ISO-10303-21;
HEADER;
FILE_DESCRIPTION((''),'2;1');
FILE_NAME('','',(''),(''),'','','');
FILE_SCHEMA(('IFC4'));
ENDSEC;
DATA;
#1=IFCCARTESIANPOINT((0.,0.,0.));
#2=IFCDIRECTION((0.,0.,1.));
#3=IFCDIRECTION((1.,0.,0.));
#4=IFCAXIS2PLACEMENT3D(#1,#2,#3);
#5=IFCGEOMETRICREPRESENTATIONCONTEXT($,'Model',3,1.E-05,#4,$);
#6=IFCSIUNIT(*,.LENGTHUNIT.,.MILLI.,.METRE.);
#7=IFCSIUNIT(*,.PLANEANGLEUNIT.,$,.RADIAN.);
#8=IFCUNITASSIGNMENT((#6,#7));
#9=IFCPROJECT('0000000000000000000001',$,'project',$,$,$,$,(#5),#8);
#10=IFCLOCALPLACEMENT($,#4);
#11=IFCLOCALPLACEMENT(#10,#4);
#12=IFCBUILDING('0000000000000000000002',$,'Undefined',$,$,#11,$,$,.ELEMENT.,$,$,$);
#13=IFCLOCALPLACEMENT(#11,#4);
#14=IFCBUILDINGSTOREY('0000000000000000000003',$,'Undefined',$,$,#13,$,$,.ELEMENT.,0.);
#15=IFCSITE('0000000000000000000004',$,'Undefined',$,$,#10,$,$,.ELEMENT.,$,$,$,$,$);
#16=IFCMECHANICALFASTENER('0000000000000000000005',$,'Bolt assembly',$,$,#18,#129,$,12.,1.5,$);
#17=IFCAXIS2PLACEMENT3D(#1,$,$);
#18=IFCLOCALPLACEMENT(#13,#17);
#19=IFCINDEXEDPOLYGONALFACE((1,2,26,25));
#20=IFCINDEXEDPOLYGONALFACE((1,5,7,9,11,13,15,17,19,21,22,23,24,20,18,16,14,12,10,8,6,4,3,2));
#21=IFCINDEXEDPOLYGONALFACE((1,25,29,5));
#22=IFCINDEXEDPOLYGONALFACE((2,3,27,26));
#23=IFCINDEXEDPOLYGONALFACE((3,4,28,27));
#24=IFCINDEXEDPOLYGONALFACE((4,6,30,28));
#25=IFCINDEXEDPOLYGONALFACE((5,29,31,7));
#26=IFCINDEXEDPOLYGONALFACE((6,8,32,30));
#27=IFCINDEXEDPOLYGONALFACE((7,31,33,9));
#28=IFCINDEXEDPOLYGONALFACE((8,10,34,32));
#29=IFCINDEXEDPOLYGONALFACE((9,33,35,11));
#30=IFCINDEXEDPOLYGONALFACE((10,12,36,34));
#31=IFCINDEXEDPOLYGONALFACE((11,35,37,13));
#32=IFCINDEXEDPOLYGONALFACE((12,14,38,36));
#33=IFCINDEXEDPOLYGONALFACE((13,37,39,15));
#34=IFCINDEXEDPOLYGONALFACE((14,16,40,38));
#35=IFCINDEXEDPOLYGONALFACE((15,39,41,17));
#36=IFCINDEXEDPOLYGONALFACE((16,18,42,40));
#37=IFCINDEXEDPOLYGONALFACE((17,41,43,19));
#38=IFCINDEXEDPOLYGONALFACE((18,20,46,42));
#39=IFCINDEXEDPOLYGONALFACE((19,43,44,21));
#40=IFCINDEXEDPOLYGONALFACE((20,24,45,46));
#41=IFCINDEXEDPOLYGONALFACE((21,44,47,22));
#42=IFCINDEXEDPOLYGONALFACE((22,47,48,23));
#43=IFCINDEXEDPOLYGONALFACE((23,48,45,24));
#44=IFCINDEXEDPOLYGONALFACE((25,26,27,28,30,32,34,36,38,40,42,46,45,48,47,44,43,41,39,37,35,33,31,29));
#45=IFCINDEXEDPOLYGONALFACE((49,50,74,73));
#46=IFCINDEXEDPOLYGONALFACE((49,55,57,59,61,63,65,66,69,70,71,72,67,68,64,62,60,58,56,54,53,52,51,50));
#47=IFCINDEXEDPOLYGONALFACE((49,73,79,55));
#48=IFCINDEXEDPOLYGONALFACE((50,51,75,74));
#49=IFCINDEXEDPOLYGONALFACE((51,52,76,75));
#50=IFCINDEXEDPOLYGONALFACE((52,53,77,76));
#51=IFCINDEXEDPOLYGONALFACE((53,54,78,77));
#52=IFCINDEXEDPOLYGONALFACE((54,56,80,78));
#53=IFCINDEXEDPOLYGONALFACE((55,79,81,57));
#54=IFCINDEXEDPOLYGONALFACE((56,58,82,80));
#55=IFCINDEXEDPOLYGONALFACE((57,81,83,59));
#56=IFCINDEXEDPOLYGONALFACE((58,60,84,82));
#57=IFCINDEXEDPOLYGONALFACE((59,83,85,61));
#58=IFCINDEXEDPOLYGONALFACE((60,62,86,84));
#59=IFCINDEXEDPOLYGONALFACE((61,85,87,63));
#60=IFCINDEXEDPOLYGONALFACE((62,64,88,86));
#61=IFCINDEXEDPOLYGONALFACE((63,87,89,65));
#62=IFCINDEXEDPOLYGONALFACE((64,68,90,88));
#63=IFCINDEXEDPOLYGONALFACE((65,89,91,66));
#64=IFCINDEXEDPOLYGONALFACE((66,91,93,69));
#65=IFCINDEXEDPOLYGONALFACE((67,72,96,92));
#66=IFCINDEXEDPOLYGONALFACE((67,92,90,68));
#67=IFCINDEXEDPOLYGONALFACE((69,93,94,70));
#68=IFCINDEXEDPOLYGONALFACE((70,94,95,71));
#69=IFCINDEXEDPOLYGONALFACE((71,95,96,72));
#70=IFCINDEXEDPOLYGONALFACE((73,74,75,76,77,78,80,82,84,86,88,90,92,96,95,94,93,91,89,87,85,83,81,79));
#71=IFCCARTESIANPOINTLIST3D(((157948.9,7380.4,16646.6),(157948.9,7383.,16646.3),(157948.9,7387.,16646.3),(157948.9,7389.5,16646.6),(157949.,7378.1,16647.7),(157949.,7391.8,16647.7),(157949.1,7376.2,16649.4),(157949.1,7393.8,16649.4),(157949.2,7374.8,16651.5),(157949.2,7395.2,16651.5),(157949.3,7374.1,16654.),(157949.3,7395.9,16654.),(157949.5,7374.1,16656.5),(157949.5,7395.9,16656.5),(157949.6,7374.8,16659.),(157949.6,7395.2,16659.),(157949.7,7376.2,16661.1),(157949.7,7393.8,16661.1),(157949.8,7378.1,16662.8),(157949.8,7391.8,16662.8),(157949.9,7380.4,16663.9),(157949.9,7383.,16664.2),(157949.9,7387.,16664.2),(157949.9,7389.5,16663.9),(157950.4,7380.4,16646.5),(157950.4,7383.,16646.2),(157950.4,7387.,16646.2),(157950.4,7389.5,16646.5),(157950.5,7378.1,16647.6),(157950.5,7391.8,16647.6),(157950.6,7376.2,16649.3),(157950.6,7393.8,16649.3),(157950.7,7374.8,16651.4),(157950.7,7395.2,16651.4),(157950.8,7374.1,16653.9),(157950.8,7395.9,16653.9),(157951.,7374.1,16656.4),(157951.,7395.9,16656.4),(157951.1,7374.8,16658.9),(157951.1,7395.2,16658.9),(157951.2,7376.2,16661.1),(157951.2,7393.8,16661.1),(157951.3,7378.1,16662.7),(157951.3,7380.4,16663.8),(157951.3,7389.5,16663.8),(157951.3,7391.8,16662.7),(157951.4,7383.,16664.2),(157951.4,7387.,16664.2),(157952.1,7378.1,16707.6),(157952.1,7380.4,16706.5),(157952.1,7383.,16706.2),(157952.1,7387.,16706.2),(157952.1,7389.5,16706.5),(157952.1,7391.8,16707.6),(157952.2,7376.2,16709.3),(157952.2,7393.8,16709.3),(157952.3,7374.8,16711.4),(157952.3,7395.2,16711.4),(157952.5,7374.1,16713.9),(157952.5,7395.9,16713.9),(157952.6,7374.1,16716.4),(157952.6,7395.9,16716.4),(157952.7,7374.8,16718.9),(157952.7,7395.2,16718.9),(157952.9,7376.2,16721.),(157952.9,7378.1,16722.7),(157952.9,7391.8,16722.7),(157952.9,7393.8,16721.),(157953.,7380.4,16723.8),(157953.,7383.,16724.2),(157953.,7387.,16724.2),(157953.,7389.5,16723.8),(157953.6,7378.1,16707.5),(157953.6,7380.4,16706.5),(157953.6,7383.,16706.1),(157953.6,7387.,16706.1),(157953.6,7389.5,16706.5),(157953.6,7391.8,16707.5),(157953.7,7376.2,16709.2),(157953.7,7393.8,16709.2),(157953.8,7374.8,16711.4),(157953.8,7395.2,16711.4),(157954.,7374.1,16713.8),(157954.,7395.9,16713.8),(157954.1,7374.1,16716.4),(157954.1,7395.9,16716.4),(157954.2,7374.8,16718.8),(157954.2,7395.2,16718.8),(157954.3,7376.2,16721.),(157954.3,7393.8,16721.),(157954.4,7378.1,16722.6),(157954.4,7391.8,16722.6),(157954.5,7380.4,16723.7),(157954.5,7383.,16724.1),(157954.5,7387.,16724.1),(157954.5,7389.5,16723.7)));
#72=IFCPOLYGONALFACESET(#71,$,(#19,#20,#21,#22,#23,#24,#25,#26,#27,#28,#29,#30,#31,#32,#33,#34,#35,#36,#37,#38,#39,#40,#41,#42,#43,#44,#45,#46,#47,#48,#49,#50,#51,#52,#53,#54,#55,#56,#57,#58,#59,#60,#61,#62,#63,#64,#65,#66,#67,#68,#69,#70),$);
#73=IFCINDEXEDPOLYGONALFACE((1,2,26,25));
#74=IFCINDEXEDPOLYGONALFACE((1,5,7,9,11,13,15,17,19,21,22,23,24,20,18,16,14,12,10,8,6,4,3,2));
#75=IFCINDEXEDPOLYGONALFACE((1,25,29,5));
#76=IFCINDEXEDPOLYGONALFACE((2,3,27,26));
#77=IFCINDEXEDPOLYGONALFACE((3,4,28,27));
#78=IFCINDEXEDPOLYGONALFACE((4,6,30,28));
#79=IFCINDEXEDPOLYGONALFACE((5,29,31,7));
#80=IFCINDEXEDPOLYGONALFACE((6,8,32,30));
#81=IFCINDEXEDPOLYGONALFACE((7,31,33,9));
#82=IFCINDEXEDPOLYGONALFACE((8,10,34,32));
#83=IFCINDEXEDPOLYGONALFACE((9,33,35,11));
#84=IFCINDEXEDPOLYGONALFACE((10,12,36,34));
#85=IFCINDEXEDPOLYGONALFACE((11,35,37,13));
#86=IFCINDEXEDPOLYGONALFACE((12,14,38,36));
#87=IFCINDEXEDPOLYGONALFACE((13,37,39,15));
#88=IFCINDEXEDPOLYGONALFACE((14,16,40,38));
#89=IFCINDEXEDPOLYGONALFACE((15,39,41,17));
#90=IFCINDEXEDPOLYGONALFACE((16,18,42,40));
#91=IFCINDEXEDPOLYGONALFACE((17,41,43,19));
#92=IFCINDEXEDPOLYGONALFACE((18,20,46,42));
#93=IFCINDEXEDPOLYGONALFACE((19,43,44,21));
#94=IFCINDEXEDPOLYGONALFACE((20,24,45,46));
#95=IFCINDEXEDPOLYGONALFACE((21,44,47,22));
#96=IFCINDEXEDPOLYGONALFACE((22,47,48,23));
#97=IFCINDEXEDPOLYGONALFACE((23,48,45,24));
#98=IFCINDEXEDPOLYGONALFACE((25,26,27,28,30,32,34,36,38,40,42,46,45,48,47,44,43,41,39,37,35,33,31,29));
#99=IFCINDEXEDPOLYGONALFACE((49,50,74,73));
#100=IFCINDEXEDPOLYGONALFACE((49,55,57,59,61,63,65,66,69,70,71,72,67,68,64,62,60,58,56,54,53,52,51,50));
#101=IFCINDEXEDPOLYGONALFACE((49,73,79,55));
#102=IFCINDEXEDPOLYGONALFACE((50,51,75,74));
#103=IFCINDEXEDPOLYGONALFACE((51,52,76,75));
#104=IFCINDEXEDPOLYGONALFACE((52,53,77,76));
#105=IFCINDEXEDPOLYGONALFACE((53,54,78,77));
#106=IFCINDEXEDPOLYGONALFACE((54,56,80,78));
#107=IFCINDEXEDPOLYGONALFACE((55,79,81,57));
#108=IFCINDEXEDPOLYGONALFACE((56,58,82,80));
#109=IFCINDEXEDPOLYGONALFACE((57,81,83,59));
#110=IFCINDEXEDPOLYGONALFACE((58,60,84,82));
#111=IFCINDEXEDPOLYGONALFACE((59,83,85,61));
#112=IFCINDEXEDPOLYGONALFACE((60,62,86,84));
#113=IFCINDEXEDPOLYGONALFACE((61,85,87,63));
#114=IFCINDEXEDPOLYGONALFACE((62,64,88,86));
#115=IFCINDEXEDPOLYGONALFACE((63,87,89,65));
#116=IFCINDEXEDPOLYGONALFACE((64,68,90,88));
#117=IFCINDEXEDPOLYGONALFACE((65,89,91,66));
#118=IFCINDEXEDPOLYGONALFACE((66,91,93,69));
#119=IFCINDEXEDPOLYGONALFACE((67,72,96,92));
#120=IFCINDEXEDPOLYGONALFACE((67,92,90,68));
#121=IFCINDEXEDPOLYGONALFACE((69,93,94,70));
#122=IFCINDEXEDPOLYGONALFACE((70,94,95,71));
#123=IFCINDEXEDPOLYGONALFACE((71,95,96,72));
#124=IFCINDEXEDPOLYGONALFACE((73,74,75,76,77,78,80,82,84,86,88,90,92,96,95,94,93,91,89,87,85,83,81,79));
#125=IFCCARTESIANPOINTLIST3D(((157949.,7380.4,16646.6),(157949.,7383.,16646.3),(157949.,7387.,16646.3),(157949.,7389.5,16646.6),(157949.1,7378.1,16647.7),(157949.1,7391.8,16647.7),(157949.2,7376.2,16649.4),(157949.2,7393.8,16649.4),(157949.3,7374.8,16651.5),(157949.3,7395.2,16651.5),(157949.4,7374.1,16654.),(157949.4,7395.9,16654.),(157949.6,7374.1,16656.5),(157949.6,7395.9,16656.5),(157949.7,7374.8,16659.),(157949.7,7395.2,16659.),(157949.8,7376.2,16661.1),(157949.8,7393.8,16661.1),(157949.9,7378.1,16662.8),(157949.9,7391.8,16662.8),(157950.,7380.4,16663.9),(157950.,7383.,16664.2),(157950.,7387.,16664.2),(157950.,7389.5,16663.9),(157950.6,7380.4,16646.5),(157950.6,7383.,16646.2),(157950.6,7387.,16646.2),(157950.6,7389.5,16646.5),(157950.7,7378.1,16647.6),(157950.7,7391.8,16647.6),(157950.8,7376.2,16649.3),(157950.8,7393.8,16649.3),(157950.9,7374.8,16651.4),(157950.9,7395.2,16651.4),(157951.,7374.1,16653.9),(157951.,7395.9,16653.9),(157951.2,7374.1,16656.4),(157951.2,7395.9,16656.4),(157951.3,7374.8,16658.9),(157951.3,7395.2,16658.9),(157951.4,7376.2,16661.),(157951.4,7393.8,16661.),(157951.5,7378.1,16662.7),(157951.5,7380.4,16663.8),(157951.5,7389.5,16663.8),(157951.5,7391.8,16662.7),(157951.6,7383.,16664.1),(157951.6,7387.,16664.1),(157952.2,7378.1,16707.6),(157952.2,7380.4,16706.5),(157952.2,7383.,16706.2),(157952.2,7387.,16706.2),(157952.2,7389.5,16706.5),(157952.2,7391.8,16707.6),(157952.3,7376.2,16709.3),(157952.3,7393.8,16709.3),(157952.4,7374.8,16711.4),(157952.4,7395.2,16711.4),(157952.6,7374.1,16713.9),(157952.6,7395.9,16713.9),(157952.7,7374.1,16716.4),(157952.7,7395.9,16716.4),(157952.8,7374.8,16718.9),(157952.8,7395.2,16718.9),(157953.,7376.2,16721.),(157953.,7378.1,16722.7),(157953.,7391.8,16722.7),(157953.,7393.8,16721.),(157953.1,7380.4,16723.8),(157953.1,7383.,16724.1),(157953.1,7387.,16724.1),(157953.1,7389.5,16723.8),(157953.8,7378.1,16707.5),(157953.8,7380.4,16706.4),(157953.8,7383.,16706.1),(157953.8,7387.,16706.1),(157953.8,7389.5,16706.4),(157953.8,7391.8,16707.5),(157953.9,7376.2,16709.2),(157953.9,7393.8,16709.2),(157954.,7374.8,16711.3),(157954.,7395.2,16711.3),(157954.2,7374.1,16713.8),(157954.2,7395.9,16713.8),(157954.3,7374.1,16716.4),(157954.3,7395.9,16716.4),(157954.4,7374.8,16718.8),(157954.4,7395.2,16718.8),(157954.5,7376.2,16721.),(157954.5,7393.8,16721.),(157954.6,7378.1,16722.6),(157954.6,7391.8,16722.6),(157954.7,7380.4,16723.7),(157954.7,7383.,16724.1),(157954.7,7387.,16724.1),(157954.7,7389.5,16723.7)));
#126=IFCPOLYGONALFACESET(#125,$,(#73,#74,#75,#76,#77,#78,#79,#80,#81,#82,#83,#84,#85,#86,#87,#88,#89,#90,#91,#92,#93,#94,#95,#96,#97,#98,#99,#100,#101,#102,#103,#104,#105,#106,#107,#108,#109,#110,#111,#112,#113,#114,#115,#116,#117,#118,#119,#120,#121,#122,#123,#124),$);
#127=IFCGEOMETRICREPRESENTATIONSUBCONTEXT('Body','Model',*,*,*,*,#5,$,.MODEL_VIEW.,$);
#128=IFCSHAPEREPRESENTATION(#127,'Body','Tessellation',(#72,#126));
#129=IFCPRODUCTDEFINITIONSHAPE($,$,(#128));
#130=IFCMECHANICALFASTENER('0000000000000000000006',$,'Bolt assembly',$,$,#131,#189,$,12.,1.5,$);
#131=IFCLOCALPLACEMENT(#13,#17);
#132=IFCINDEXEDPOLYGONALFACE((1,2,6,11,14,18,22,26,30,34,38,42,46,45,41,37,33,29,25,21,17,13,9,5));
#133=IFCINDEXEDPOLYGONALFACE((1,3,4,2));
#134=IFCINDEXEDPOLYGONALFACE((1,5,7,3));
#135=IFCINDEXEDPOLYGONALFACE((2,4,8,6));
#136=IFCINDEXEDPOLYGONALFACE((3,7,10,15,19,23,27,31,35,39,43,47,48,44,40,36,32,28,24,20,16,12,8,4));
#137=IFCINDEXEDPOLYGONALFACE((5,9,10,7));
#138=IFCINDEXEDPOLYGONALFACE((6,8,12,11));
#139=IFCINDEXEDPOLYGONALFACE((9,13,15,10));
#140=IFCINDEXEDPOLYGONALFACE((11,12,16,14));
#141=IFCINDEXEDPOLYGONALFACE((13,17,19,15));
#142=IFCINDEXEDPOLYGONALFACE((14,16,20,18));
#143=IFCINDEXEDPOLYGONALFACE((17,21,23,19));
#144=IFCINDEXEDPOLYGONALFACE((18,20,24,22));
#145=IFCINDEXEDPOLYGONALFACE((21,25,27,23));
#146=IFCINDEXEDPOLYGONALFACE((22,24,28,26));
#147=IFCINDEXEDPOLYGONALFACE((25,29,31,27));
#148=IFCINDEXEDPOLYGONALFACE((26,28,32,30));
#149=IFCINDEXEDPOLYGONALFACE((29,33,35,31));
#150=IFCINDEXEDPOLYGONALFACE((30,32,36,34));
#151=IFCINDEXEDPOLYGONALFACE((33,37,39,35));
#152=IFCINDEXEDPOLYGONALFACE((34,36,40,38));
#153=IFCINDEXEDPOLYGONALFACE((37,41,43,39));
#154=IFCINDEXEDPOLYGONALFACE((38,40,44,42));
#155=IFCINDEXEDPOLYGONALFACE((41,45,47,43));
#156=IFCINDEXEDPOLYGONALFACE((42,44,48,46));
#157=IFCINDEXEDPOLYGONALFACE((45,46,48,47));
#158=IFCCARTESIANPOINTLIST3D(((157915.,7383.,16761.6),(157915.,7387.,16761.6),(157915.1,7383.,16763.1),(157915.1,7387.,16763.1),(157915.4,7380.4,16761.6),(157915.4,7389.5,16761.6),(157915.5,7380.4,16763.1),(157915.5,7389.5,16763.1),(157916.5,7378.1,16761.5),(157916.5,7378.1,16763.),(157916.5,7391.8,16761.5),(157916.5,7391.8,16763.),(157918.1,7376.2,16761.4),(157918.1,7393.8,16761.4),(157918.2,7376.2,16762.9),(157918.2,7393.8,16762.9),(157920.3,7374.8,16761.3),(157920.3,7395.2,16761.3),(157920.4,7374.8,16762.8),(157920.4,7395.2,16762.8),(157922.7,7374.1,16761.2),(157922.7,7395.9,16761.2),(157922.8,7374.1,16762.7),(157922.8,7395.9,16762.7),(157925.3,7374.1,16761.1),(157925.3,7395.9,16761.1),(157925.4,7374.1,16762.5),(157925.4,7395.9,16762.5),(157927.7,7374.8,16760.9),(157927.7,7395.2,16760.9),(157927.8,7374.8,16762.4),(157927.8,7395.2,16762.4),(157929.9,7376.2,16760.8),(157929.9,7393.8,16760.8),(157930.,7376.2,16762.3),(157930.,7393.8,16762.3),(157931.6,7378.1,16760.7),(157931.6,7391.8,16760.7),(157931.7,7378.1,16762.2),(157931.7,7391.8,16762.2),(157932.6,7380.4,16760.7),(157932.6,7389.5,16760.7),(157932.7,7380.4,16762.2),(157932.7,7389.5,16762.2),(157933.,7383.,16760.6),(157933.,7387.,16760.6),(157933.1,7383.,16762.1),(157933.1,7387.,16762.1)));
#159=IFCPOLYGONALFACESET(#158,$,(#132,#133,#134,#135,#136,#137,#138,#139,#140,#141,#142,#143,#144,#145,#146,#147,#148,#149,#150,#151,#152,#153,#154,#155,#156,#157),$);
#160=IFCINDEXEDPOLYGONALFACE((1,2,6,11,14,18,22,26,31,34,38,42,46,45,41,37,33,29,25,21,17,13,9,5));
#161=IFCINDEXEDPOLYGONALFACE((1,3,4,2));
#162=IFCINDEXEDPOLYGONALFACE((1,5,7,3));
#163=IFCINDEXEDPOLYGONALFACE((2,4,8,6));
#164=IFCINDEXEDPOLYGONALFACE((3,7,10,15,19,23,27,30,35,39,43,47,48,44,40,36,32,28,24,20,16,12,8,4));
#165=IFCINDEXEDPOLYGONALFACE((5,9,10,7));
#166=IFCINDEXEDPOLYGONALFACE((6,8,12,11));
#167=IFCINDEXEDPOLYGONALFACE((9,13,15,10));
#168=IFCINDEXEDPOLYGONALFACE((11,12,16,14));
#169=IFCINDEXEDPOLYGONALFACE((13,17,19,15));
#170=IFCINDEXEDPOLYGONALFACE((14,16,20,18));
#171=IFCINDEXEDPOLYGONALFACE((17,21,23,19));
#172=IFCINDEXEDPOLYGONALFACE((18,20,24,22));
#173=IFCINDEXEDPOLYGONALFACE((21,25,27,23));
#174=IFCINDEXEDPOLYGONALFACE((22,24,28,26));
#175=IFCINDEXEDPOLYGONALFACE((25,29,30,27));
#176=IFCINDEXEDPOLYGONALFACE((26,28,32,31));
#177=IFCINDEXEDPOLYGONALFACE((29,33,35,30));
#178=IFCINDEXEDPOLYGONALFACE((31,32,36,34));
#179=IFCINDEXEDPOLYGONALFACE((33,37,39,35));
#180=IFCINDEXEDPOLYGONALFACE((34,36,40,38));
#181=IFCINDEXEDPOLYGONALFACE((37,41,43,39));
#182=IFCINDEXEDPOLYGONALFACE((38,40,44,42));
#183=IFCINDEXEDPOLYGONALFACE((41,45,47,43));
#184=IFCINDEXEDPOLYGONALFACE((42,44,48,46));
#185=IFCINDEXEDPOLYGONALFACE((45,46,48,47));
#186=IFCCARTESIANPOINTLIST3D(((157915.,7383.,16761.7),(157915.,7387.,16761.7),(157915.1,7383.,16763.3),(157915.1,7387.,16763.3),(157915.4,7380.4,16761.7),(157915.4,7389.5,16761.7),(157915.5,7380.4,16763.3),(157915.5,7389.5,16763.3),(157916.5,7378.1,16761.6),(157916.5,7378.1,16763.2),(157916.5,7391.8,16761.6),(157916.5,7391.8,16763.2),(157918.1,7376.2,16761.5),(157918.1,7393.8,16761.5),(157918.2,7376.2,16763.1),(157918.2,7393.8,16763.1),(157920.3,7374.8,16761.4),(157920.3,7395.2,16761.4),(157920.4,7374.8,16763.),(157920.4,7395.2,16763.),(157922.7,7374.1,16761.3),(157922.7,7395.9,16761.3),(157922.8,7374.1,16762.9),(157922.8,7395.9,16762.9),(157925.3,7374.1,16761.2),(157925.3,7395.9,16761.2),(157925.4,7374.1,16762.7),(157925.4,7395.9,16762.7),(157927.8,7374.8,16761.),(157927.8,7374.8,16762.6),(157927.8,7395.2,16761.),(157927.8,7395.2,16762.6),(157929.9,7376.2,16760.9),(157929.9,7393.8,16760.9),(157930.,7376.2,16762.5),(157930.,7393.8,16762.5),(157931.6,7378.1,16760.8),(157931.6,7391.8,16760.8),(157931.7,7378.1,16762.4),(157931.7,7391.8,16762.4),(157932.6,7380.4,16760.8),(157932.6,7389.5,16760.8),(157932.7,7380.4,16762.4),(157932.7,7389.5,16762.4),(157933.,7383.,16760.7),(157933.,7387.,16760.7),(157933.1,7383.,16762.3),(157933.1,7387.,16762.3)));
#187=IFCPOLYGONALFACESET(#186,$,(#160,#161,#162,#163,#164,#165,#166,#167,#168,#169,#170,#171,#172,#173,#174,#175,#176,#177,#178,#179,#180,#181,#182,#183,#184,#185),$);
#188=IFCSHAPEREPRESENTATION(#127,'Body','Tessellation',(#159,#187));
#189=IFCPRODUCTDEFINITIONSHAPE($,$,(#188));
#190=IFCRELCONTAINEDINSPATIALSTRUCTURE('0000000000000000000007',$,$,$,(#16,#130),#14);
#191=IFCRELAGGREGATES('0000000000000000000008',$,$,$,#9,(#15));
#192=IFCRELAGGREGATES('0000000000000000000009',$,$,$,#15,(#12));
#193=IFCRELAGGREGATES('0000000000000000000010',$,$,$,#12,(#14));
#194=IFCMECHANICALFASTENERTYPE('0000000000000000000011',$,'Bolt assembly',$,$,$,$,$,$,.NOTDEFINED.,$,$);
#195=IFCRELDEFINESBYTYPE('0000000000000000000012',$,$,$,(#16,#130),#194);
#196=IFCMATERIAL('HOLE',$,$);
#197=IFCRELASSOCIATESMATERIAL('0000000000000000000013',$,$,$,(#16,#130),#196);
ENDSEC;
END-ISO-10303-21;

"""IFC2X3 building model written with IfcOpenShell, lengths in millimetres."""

from ifc_helpers import new_model, entity, si_unit, frame, origin_with_axes, place, context, subcontext, project, spatial, source, transform, mapped, material, type_object, element, save


model = new_model("IFC2X3")

# Units and contexts
model_context = context("Model", 3, precision=1e-05, world=origin_with_axes())
body_context = subcontext(model_context, "Body", "Model", "MODEL_VIEW")
ifc_project = project(units=[si_unit("LENGTHUNIT", "METRE", prefix="MILLI"), si_unit("PLANEANGLEUNIT", "RADIAN")], contexts=[model_context])

# Site, building, storey
site_placement = place(None, origin_with_axes())
site = spatial("IfcSite", under=ifc_project, at=site_placement, Name="Undefined", CompositionType="ELEMENT")
building_placement = place(site_placement, origin_with_axes())
building = spatial("IfcBuilding", under=site, at=building_placement, Name="Undefined", CompositionType="ELEMENT")
storey_placement = place(building_placement, origin_with_axes())
storey = spatial("IfcBuildingStorey", under=building, at=storey_placement, Name="Undefined", CompositionType="ELEMENT", Elevation=0.0)

# Mechanical fasteners
ifc_material_1 = material(Name="HOLE")
mechanical_fastener_type = type_object("IfcMechanicalFastenerType", Name="Bolt assembly")
shared_circle_1 = entity("IfcCircle", entity("IfcAxis2Placement2D", entity("IfcCartesianPoint", [0.0, -2.0]), entity("IfcDirection", [1.0, 0.0])), 9.0)
shared_circle_2 = entity("IfcCircle", entity("IfcAxis2Placement2D", entity("IfcCartesianPoint", [0.0, 2.0]), entity("IfcDirection", [-1.0, 0.0])), 9.0)
shared_composite_curve = entity("IfcCompositeCurve", [entity("IfcCompositeCurveSegment", "CONTINUOUS", True, entity("IfcPolyline", [entity("IfcCartesianPoint", [9.0, 2.0]), entity("IfcCartesianPoint", [9.0, -2.0])])), entity("IfcCompositeCurveSegment", "CONTINUOUS", True, entity("IfcTrimmedCurve", shared_circle_1, [entity("IfcParameterValue", 0.0)], [entity("IfcParameterValue", 3.141593)], False, "PARAMETER")), entity("IfcCompositeCurveSegment", "CONTINUOUS", True, entity("IfcPolyline", [entity("IfcCartesianPoint", [-9.0, -2.0]), entity("IfcCartesianPoint", [-9.0, 2.0])])), entity("IfcCompositeCurveSegment", "DISCONTINUOUS", True, entity("IfcTrimmedCurve", shared_circle_2, [entity("IfcParameterValue", 0.0)], [entity("IfcParameterValue", 3.141593)], False, "PARAMETER"))], False)
shared_shape_1 = source(origin_with_axes(), body_context, "Body", "SweptSolid", [
    entity("IfcExtrudedAreaSolid", entity("IfcArbitraryClosedProfileDef", "AREA", None, shared_composite_curve), entity("IfcAxis2Placement3D", entity("IfcCartesianPoint", [0.0, 0.1, 0.0]), entity("IfcDirection", [0.0, 1.0, 0.0]), entity("IfcDirection", [1.0, 0.0, 0.0])), entity("IfcDirection", [0.0, 0.0, 1.0]), 1.5),
    entity("IfcExtrudedAreaSolid", entity("IfcArbitraryClosedProfileDef", "AREA", None, shared_composite_curve), entity("IfcAxis2Placement3D", entity("IfcCartesianPoint", [0.0, -0.1, 0.0]), entity("IfcDirection", [0.0, 1.0, 0.0]), entity("IfcDirection", [1.0, 0.0, 0.0])), entity("IfcDirection", [0.0, 0.0, 1.0]), 1.6),
])
mechanical_fastener_1_placement = place(storey_placement, frame((157954.1, 7385.0, 16715.1), z_axis=(0.0, 1.0, 0.0), x_axis=(-0.052392, 0.0, -0.998627)))
element("IfcMechanicalFastener", 1, at=mechanical_fastener_1_placement, inside=storey, type_object=mechanical_fastener_type, material=ifc_material_1, Name="Bolt assembly", NominalDiameter=12.0, NominalLength=1.5, context=body_context, shape_type="MappedRepresentation", body=[
    mapped(shared_shape_1, transform((0.0, 0.0, 0.0))),
    mapped(shared_shape_1, transform((60.0, 0.0, 0.0))),
])
shared_shape_2 = source(origin_with_axes(), body_context, "Body", "SweptSolid", [
    entity("IfcExtrudedAreaSolid", entity("IfcArbitraryClosedProfileDef", "AREA", None, shared_composite_curve), entity("IfcAxis2Placement3D", entity("IfcCartesianPoint", [0.0, -0.9, 0.0]), entity("IfcDirection", [0.0, 1.0, 0.0]), entity("IfcDirection", [1.0, 0.0, 0.0])), entity("IfcDirection", [0.0, 0.0, 1.0]), 1.5),
    entity("IfcExtrudedAreaSolid", entity("IfcArbitraryClosedProfileDef", "AREA", None, shared_composite_curve), entity("IfcAxis2Placement3D", entity("IfcCartesianPoint", [0.0, -1.1, 0.0]), entity("IfcDirection", [0.0, 1.0, 0.0]), entity("IfcDirection", [1.0, 0.0, 0.0])), entity("IfcDirection", [0.0, 0.0, 1.0]), 1.6),
])
mechanical_fastener_2_placement = place(storey_placement, frame((157924.0, 7385.0, 16761.7), z_axis=(0.0, 1.0, 0.0), x_axis=(0.998627, 0.0, -0.052392)))
element("IfcMechanicalFastener", 2, at=mechanical_fastener_2_placement, inside=storey, type_object=mechanical_fastener_type, material=ifc_material_1, Name="Bolt assembly", NominalDiameter=12.0, NominalLength=1.5, context=body_context, shape_type="MappedRepresentation", body=[
    mapped(shared_shape_2, transform((0.0, 0.0, 0.0))),
])

save(model, "model.ifc")
